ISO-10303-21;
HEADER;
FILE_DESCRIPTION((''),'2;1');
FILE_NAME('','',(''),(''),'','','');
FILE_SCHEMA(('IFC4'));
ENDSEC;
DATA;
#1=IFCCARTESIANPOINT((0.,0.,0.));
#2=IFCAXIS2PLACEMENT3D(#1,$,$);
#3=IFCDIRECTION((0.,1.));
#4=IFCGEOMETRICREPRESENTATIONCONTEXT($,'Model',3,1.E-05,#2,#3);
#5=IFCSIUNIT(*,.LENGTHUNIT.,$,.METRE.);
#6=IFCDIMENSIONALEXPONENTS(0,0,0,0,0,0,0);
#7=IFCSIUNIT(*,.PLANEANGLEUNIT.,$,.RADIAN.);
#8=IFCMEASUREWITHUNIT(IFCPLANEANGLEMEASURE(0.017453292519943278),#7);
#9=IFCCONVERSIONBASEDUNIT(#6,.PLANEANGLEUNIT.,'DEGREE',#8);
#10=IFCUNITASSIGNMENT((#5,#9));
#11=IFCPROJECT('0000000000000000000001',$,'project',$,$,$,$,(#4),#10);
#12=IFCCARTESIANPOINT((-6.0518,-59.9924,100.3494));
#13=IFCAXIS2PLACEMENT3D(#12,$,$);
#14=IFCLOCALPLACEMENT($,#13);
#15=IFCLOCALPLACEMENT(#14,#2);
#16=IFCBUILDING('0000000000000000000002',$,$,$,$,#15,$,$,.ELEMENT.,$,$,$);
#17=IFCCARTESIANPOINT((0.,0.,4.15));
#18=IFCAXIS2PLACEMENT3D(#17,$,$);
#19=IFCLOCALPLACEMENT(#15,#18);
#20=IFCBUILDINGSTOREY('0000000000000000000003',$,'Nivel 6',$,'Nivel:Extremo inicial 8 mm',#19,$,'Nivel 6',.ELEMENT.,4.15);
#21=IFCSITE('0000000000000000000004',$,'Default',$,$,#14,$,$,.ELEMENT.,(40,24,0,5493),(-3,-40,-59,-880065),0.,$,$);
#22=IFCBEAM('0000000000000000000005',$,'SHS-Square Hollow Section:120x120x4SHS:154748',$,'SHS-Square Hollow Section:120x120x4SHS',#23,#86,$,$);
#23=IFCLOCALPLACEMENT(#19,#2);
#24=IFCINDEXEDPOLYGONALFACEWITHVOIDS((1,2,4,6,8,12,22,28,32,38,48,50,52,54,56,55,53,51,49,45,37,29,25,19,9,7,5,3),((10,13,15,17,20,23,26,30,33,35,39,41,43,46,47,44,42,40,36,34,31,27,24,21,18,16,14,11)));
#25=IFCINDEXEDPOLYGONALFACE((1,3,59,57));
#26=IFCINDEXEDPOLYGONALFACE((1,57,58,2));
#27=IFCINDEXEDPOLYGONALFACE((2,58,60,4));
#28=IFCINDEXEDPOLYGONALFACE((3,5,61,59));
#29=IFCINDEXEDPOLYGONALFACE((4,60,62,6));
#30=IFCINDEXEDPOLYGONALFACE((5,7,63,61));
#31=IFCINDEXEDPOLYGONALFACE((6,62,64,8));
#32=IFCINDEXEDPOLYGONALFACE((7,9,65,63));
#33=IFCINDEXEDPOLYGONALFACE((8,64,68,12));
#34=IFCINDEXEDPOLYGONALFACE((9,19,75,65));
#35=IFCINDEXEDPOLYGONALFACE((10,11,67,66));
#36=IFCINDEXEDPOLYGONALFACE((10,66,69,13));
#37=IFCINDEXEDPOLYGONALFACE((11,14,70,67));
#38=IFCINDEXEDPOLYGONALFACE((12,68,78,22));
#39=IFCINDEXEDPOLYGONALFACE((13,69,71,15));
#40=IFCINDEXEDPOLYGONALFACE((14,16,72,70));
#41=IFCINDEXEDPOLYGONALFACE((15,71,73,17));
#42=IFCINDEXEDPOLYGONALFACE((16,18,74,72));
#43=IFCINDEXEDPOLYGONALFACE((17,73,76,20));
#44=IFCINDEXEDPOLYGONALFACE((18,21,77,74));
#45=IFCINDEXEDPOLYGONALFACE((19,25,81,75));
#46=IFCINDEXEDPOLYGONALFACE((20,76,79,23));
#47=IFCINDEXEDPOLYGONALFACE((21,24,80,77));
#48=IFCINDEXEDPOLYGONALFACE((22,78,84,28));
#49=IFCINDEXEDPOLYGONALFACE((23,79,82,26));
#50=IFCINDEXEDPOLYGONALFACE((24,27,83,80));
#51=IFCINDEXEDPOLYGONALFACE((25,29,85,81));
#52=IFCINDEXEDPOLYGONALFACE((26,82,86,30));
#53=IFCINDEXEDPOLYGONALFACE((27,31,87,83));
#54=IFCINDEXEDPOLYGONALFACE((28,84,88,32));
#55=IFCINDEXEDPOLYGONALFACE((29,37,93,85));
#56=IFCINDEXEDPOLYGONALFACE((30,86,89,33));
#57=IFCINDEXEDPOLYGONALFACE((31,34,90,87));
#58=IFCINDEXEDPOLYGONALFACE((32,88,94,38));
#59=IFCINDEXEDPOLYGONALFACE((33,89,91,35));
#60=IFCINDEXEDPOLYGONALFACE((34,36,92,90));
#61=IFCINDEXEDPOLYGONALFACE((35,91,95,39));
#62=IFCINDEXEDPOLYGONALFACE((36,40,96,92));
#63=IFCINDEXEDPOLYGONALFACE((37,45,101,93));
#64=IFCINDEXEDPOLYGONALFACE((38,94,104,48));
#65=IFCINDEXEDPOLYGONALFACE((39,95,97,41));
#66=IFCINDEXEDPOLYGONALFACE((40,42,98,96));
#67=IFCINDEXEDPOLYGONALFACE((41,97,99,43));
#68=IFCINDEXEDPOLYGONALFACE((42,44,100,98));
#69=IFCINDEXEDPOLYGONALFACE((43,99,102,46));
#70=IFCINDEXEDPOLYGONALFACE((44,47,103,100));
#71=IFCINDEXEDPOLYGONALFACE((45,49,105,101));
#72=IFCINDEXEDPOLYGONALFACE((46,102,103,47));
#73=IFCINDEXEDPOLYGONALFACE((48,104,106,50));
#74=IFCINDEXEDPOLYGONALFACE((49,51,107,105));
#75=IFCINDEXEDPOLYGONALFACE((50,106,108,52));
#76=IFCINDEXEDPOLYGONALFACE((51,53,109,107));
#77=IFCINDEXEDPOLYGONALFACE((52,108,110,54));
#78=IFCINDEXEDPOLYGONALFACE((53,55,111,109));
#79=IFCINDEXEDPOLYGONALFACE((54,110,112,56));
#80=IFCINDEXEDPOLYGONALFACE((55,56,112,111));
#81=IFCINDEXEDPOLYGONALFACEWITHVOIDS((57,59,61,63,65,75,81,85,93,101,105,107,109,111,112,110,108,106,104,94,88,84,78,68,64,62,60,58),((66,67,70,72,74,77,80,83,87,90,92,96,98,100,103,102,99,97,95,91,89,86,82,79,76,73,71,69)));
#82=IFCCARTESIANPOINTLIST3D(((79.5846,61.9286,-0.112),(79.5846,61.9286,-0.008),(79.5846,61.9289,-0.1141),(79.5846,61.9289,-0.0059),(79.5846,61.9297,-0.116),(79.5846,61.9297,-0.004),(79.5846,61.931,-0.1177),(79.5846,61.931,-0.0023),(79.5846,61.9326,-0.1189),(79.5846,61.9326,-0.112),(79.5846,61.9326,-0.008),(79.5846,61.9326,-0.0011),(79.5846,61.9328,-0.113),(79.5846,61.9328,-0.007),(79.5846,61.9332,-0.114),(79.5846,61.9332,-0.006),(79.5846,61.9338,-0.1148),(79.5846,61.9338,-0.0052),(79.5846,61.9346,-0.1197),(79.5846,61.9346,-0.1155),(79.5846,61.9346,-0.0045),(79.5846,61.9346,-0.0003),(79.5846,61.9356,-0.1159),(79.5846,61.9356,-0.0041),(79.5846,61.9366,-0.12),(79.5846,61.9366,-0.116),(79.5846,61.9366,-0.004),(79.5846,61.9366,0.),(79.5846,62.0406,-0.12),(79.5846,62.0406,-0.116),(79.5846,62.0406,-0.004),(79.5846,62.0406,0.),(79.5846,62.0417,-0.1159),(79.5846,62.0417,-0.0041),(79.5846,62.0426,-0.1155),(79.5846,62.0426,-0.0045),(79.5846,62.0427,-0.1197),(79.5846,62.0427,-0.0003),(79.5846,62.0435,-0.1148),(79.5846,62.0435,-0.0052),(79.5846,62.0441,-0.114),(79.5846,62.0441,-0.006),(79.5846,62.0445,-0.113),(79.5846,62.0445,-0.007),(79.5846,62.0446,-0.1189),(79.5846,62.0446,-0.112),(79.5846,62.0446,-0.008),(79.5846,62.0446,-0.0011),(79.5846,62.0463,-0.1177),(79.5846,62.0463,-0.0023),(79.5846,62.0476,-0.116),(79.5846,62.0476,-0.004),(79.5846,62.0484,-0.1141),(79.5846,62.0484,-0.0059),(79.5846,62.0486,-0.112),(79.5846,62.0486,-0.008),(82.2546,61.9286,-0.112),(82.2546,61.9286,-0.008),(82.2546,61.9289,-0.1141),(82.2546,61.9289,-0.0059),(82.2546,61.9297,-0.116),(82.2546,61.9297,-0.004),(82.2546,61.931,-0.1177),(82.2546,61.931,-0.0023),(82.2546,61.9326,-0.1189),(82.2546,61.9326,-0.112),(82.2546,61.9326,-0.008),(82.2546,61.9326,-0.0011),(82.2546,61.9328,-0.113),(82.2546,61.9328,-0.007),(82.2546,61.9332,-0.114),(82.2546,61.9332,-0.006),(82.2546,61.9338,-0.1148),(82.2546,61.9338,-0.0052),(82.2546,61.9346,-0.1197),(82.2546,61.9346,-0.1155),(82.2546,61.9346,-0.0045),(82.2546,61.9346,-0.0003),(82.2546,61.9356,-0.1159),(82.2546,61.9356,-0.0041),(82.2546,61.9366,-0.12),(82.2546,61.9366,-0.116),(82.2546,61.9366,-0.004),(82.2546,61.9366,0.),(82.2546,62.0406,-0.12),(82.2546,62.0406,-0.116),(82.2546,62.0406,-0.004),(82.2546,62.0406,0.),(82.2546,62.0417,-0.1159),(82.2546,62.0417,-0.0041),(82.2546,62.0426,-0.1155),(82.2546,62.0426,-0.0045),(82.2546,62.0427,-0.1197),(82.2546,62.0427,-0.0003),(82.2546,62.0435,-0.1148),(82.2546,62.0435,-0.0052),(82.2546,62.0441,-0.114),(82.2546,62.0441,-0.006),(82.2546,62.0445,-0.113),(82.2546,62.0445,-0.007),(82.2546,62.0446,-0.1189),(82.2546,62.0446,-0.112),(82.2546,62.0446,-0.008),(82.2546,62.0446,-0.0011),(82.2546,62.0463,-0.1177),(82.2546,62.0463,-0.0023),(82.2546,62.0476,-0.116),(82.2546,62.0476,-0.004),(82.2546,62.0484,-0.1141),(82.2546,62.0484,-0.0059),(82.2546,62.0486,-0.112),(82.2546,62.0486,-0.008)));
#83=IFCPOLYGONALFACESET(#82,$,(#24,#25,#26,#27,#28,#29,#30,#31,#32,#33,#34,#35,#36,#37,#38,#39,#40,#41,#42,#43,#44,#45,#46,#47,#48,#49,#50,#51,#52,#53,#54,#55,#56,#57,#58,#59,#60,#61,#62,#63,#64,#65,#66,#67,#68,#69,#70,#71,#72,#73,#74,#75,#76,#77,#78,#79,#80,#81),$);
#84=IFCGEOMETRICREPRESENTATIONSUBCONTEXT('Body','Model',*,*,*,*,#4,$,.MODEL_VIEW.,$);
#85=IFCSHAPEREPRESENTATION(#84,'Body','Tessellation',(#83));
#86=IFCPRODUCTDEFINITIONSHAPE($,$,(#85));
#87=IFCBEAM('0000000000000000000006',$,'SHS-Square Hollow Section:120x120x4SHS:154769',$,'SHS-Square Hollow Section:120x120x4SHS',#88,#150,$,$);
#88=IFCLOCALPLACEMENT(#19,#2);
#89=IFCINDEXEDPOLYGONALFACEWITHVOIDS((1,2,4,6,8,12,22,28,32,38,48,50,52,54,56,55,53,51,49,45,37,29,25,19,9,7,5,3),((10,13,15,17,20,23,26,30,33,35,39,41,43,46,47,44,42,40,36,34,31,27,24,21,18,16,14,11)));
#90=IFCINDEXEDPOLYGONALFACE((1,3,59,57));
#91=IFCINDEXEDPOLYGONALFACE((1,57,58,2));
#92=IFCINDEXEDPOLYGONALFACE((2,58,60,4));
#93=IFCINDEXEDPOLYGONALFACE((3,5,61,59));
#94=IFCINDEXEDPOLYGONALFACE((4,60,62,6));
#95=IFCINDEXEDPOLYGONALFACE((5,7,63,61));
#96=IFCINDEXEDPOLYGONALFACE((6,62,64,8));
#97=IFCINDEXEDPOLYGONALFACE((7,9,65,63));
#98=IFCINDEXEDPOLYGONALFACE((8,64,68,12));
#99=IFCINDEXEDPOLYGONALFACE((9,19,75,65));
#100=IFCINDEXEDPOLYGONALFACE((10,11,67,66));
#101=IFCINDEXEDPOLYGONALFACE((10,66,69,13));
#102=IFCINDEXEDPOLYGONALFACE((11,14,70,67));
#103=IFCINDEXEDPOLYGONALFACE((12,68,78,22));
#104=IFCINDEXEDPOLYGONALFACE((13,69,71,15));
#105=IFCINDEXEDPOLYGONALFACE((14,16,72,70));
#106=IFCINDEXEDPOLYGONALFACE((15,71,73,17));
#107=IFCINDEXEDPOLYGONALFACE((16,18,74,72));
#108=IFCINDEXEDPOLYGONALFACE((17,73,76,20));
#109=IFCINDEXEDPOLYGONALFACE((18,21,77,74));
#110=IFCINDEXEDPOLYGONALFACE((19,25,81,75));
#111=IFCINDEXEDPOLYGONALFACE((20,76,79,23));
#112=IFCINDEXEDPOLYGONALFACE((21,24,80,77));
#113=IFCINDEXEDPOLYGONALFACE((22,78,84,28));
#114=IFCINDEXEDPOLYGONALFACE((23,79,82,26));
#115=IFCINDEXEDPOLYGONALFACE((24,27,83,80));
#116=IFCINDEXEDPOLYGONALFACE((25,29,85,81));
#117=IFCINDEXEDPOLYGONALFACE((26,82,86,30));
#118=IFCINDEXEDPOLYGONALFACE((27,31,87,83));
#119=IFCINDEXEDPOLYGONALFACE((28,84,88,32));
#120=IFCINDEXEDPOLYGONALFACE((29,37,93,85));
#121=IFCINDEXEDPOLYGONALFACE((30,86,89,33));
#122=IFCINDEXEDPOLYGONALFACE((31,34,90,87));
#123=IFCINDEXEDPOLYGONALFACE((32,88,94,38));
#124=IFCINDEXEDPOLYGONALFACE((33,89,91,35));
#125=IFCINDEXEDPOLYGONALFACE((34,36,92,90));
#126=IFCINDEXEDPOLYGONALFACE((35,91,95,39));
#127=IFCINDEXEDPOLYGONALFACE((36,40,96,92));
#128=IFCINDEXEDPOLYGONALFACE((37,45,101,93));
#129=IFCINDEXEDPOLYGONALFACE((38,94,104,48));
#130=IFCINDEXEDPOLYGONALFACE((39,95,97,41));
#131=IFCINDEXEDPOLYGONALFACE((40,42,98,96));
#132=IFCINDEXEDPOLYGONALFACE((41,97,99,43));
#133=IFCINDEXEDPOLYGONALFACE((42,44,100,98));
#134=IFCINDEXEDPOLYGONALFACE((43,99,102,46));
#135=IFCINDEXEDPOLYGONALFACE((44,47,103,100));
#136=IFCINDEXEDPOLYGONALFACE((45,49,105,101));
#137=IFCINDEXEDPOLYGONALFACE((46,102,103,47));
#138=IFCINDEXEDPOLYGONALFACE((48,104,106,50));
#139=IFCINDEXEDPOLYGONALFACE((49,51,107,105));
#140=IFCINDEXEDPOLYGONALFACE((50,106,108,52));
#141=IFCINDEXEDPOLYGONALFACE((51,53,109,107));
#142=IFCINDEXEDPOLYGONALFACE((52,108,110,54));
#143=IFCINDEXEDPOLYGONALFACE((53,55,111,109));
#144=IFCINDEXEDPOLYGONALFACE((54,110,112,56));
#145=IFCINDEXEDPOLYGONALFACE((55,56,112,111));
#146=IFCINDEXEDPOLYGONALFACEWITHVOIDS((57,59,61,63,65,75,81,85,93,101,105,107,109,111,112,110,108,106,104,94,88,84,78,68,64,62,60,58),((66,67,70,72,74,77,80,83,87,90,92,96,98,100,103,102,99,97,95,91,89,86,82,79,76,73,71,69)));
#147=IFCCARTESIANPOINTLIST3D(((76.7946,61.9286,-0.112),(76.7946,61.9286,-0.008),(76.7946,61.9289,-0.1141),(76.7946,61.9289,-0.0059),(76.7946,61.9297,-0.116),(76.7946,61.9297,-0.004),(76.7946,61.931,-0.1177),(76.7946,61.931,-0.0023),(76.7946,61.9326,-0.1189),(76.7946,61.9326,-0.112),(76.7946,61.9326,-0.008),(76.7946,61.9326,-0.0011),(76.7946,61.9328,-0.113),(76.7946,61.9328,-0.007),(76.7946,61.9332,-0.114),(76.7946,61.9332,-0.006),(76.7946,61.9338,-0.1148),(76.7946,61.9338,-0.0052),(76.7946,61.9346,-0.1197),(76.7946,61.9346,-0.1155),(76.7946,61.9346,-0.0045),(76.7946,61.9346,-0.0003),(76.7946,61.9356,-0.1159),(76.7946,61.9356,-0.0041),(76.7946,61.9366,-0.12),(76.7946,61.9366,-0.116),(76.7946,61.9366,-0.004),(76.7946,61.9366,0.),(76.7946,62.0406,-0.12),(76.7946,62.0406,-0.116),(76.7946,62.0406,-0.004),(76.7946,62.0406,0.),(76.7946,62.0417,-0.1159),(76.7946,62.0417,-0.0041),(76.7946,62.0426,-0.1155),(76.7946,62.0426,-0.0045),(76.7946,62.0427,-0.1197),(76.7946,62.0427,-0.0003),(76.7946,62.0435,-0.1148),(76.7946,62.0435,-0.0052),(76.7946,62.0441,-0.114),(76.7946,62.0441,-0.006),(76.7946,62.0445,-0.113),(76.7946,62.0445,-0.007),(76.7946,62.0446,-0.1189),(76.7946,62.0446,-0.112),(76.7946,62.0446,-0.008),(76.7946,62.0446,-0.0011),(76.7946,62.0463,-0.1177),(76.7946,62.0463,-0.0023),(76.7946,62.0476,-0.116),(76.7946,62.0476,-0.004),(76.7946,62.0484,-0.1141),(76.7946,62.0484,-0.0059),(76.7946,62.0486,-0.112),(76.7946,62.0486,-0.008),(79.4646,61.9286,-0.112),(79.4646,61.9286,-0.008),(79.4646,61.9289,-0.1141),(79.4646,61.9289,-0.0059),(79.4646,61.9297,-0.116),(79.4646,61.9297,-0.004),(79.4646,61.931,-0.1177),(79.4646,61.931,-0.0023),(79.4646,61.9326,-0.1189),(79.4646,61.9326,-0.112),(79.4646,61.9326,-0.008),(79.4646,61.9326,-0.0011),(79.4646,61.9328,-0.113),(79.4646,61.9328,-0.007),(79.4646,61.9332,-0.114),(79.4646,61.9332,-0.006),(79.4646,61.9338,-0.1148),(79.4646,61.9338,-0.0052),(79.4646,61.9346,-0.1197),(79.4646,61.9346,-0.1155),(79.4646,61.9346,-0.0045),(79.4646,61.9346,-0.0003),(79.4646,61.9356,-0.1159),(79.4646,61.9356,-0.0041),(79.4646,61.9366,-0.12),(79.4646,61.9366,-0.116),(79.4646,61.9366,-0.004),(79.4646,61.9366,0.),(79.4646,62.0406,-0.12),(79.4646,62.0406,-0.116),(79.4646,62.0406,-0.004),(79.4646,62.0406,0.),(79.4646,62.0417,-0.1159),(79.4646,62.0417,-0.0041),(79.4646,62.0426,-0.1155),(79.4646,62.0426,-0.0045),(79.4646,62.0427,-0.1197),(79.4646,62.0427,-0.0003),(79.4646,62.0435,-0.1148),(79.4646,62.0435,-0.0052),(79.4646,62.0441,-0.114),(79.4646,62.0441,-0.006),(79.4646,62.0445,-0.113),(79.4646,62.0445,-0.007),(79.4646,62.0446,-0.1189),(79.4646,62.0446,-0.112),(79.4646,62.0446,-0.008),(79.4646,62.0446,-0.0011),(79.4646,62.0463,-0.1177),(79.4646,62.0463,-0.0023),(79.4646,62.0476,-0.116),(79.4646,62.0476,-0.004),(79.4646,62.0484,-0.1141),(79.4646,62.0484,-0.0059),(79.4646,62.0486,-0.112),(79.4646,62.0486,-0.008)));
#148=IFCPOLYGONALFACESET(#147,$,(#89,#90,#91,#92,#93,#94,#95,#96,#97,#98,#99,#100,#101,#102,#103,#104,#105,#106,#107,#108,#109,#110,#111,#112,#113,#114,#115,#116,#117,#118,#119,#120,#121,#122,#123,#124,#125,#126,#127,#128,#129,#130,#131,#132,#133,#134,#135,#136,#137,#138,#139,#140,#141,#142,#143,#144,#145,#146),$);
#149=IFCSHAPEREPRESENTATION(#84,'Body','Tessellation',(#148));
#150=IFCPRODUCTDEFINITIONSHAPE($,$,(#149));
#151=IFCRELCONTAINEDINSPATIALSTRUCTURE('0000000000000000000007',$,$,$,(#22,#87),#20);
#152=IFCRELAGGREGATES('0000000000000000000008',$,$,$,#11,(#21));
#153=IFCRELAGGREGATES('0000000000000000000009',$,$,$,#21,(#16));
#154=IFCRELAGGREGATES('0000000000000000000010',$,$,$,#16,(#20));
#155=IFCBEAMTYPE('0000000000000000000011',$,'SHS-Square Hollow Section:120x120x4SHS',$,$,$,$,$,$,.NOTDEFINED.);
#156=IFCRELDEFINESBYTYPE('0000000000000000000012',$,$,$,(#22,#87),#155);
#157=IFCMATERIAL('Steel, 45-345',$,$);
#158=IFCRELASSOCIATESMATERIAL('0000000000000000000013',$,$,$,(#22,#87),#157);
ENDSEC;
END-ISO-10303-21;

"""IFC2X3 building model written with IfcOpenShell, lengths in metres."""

from ifc_helpers import new_model, entity, si_unit, converted_unit, direction, frame, frame_2d, origin, place, context, subcontext, project, spatial, polyline, circle_curve, parameter, trimmed, segment, composite_curve, outline, extrude, material, type_object, element, save


model = new_model("IFC2X3")

# Units and contexts
model_context = context("Model", 3, precision=1e-05, world=origin(), true_north=direction((0.0, 1.0)))
body_context = subcontext(model_context, "Body", "Model", "MODEL_VIEW")
ifc_project = project(units=[si_unit("LENGTHUNIT", "METRE"), converted_unit("PLANEANGLEUNIT", "DEGREE", entity("IfcPlaneAngleMeasure", 0.017453292519943278), si_unit("PLANEANGLEUNIT", "RADIAN"), dimensions=[0, 0, 0, 0, 0, 0, 0])], contexts=[model_context])

# Site, building, storey
site_placement = place(None, frame((-6.0518, -59.9924, 100.3494)))
site = spatial("IfcSite", under=ifc_project, at=site_placement, Name="Default", CompositionType="ELEMENT", RefLatitude=(40, 24, 0, 5493), RefLongitude=(-3, -40, -59, -880065), RefElevation=0.0)
building_placement = place(site_placement, origin())
building = spatial("IfcBuilding", under=site, at=building_placement, CompositionType="ELEMENT")
storey_placement = place(building_placement, frame((0.0, 0.0, 4.15)))
storey = spatial("IfcBuildingStorey", under=building, at=storey_placement, Name="Nivel 6", ObjectType="Nivel:Extremo inicial 8 mm", LongName="Nivel 6", CompositionType="ELEMENT", Elevation=4.15)

# Beams
ifc_material_1 = material(Name="Steel, 45-345")
beam_type_1 = type_object("IfcBeamType", Name="SHS-Square Hollow Section:120x120x4SHS", PredefinedType="NOTDEFINED")
beam_1_placement = place(storey_placement, frame((82.3146, 61.9886, 0.0), z_axis=(0.0, 0.0, 1.0), x_axis=(-1.0, 0.0, 0.0)))
element("IfcBeam", 1, at=beam_1_placement, inside=storey, type_object=beam_type_1, material=ifc_material_1, Name="SHS-Square Hollow Section:120x120x4SHS:154748", ObjectType="SHS-Square Hollow Section:120x120x4SHS", context=body_context, shape_type="SweptSolid", body=[
    extrude(outline(composite_curve([segment(trimmed(circle_curve(frame_2d((-0.052, -0.052), x_axis=(1.0, 0.0)), 0.008), [parameter(180.0)], [parameter(270.0)], True, "PARAMETER"), True, "CONTINUOUS"), segment(polyline([(-0.052, -0.06), (0.052, -0.06)]), True, "CONTINUOUS"), segment(trimmed(circle_curve(frame_2d((0.052, -0.052), x_axis=(1.0, 0.0)), 0.008), [parameter(270.0)], [parameter(0.0)], True, "PARAMETER"), True, "CONTINUOUS"), segment(polyline([(0.06, -0.052), (0.06, 0.052)]), True, "CONTINUOUS"), segment(trimmed(circle_curve(frame_2d((0.052, 0.052), x_axis=(1.0, 0.0)), 0.008), [parameter(360.0)], [parameter(90.0)], True, "PARAMETER"), True, "CONTINUOUS"), segment(polyline([(0.052, 0.06), (-0.052, 0.06)]), True, "CONTINUOUS"), segment(trimmed(circle_curve(frame_2d((-0.052, 0.052), x_axis=(1.0, 0.0)), 0.008), [parameter(90.0)], [parameter(180.0)], True, "PARAMETER"), True, "CONTINUOUS"), segment(polyline([(-0.06, 0.052), (-0.06, -0.052)]), True, "CONTINUOUS")], self_intersect=False), holes=[composite_curve([segment(polyline([(0.052, -0.056), (-0.052, -0.056)]), True, "CONTINUOUS"), segment(trimmed(circle_curve(frame_2d((-0.052, -0.052), x_axis=(1.0, 0.0)), 0.004), [parameter(180.0)], [parameter(270.0)], True, "PARAMETER"), False, "CONTINUOUS"), segment(polyline([(-0.056, -0.052), (-0.056, 0.052)]), True, "CONTINUOUS"), segment(trimmed(circle_curve(frame_2d((-0.052, 0.052), x_axis=(1.0, 0.0)), 0.004), [parameter(90.0)], [parameter(180.0)], True, "PARAMETER"), False, "CONTINUOUS"), segment(polyline([(-0.052, 0.056), (0.052, 0.056)]), True, "CONTINUOUS"), segment(trimmed(circle_curve(frame_2d((0.052, 0.052), x_axis=(1.0, 0.0)), 0.004), [parameter(0.0)], [parameter(90.0)], True, "PARAMETER"), False, "CONTINUOUS"), segment(polyline([(0.056, 0.052), (0.056, -0.052)]), True, "CONTINUOUS"), segment(trimmed(circle_curve(frame_2d((0.052, -0.052), x_axis=(1.0, 0.0)), 0.004), [parameter(270.0)], [parameter(0.0)], True, "PARAMETER"), False, "CONTINUOUS")], self_intersect=False)]), frame((0.06, 0.0, -0.06), z_axis=(1.0, 0.0, 0.0), x_axis=(0.0, -1.0, 0.0)), (0.0, 0.0, 1.0), 2.67),
])
beam_2_placement = place(storey_placement, frame((79.5246, 61.9886, 0.0), z_axis=(0.0, 0.0, 1.0), x_axis=(-1.0, 0.0, 0.0)))
element("IfcBeam", 2, at=beam_2_placement, inside=storey, type_object=beam_type_1, material=ifc_material_1, Name="SHS-Square Hollow Section:120x120x4SHS:154769", ObjectType="SHS-Square Hollow Section:120x120x4SHS", context=body_context, shape_type="SweptSolid", body=[
    extrude(outline(composite_curve([segment(trimmed(circle_curve(frame_2d((-0.052, -0.052), x_axis=(1.0, 0.0)), 0.008), [parameter(180.0)], [parameter(270.0)], True, "PARAMETER"), True, "CONTINUOUS"), segment(polyline([(-0.052, -0.06), (0.052, -0.06)]), True, "CONTINUOUS"), segment(trimmed(circle_curve(frame_2d((0.052, -0.052), x_axis=(1.0, 0.0)), 0.008), [parameter(270.0)], [parameter(0.0)], True, "PARAMETER"), True, "CONTINUOUS"), segment(polyline([(0.06, -0.052), (0.06, 0.052)]), True, "CONTINUOUS"), segment(trimmed(circle_curve(frame_2d((0.052, 0.052), x_axis=(1.0, 0.0)), 0.008), [parameter(360.0)], [parameter(90.0)], True, "PARAMETER"), True, "CONTINUOUS"), segment(polyline([(0.052, 0.06), (-0.052, 0.06)]), True, "CONTINUOUS"), segment(trimmed(circle_curve(frame_2d((-0.052, 0.052), x_axis=(1.0, 0.0)), 0.008), [parameter(90.0)], [parameter(180.0)], True, "PARAMETER"), True, "CONTINUOUS"), segment(polyline([(-0.06, 0.052), (-0.06, -0.052)]), True, "CONTINUOUS")], self_intersect=False), holes=[composite_curve([segment(polyline([(0.052, -0.056), (-0.052, -0.056)]), True, "CONTINUOUS"), segment(trimmed(circle_curve(frame_2d((-0.052, -0.052), x_axis=(1.0, 0.0)), 0.004), [parameter(180.0)], [parameter(270.0)], True, "PARAMETER"), False, "CONTINUOUS"), segment(polyline([(-0.056, -0.052), (-0.056, 0.052)]), True, "CONTINUOUS"), segment(trimmed(circle_curve(frame_2d((-0.052, 0.052), x_axis=(1.0, 0.0)), 0.004), [parameter(90.0)], [parameter(180.0)], True, "PARAMETER"), False, "CONTINUOUS"), segment(polyline([(-0.052, 0.056), (0.052, 0.056)]), True, "CONTINUOUS"), segment(trimmed(circle_curve(frame_2d((0.052, 0.052), x_axis=(1.0, 0.0)), 0.004), [parameter(0.0)], [parameter(90.0)], True, "PARAMETER"), False, "CONTINUOUS"), segment(polyline([(0.056, 0.052), (0.056, -0.052)]), True, "CONTINUOUS"), segment(trimmed(circle_curve(frame_2d((0.052, -0.052), x_axis=(1.0, 0.0)), 0.004), [parameter(270.0)], [parameter(0.0)], True, "PARAMETER"), False, "CONTINUOUS")], self_intersect=False)]), frame((0.06, 0.0, -0.06), z_axis=(1.0, 0.0, 0.0), x_axis=(0.0, -1.0, 0.0)), (0.0, 0.0, 1.0), 2.67),
])

save(model, "model.ifc")
